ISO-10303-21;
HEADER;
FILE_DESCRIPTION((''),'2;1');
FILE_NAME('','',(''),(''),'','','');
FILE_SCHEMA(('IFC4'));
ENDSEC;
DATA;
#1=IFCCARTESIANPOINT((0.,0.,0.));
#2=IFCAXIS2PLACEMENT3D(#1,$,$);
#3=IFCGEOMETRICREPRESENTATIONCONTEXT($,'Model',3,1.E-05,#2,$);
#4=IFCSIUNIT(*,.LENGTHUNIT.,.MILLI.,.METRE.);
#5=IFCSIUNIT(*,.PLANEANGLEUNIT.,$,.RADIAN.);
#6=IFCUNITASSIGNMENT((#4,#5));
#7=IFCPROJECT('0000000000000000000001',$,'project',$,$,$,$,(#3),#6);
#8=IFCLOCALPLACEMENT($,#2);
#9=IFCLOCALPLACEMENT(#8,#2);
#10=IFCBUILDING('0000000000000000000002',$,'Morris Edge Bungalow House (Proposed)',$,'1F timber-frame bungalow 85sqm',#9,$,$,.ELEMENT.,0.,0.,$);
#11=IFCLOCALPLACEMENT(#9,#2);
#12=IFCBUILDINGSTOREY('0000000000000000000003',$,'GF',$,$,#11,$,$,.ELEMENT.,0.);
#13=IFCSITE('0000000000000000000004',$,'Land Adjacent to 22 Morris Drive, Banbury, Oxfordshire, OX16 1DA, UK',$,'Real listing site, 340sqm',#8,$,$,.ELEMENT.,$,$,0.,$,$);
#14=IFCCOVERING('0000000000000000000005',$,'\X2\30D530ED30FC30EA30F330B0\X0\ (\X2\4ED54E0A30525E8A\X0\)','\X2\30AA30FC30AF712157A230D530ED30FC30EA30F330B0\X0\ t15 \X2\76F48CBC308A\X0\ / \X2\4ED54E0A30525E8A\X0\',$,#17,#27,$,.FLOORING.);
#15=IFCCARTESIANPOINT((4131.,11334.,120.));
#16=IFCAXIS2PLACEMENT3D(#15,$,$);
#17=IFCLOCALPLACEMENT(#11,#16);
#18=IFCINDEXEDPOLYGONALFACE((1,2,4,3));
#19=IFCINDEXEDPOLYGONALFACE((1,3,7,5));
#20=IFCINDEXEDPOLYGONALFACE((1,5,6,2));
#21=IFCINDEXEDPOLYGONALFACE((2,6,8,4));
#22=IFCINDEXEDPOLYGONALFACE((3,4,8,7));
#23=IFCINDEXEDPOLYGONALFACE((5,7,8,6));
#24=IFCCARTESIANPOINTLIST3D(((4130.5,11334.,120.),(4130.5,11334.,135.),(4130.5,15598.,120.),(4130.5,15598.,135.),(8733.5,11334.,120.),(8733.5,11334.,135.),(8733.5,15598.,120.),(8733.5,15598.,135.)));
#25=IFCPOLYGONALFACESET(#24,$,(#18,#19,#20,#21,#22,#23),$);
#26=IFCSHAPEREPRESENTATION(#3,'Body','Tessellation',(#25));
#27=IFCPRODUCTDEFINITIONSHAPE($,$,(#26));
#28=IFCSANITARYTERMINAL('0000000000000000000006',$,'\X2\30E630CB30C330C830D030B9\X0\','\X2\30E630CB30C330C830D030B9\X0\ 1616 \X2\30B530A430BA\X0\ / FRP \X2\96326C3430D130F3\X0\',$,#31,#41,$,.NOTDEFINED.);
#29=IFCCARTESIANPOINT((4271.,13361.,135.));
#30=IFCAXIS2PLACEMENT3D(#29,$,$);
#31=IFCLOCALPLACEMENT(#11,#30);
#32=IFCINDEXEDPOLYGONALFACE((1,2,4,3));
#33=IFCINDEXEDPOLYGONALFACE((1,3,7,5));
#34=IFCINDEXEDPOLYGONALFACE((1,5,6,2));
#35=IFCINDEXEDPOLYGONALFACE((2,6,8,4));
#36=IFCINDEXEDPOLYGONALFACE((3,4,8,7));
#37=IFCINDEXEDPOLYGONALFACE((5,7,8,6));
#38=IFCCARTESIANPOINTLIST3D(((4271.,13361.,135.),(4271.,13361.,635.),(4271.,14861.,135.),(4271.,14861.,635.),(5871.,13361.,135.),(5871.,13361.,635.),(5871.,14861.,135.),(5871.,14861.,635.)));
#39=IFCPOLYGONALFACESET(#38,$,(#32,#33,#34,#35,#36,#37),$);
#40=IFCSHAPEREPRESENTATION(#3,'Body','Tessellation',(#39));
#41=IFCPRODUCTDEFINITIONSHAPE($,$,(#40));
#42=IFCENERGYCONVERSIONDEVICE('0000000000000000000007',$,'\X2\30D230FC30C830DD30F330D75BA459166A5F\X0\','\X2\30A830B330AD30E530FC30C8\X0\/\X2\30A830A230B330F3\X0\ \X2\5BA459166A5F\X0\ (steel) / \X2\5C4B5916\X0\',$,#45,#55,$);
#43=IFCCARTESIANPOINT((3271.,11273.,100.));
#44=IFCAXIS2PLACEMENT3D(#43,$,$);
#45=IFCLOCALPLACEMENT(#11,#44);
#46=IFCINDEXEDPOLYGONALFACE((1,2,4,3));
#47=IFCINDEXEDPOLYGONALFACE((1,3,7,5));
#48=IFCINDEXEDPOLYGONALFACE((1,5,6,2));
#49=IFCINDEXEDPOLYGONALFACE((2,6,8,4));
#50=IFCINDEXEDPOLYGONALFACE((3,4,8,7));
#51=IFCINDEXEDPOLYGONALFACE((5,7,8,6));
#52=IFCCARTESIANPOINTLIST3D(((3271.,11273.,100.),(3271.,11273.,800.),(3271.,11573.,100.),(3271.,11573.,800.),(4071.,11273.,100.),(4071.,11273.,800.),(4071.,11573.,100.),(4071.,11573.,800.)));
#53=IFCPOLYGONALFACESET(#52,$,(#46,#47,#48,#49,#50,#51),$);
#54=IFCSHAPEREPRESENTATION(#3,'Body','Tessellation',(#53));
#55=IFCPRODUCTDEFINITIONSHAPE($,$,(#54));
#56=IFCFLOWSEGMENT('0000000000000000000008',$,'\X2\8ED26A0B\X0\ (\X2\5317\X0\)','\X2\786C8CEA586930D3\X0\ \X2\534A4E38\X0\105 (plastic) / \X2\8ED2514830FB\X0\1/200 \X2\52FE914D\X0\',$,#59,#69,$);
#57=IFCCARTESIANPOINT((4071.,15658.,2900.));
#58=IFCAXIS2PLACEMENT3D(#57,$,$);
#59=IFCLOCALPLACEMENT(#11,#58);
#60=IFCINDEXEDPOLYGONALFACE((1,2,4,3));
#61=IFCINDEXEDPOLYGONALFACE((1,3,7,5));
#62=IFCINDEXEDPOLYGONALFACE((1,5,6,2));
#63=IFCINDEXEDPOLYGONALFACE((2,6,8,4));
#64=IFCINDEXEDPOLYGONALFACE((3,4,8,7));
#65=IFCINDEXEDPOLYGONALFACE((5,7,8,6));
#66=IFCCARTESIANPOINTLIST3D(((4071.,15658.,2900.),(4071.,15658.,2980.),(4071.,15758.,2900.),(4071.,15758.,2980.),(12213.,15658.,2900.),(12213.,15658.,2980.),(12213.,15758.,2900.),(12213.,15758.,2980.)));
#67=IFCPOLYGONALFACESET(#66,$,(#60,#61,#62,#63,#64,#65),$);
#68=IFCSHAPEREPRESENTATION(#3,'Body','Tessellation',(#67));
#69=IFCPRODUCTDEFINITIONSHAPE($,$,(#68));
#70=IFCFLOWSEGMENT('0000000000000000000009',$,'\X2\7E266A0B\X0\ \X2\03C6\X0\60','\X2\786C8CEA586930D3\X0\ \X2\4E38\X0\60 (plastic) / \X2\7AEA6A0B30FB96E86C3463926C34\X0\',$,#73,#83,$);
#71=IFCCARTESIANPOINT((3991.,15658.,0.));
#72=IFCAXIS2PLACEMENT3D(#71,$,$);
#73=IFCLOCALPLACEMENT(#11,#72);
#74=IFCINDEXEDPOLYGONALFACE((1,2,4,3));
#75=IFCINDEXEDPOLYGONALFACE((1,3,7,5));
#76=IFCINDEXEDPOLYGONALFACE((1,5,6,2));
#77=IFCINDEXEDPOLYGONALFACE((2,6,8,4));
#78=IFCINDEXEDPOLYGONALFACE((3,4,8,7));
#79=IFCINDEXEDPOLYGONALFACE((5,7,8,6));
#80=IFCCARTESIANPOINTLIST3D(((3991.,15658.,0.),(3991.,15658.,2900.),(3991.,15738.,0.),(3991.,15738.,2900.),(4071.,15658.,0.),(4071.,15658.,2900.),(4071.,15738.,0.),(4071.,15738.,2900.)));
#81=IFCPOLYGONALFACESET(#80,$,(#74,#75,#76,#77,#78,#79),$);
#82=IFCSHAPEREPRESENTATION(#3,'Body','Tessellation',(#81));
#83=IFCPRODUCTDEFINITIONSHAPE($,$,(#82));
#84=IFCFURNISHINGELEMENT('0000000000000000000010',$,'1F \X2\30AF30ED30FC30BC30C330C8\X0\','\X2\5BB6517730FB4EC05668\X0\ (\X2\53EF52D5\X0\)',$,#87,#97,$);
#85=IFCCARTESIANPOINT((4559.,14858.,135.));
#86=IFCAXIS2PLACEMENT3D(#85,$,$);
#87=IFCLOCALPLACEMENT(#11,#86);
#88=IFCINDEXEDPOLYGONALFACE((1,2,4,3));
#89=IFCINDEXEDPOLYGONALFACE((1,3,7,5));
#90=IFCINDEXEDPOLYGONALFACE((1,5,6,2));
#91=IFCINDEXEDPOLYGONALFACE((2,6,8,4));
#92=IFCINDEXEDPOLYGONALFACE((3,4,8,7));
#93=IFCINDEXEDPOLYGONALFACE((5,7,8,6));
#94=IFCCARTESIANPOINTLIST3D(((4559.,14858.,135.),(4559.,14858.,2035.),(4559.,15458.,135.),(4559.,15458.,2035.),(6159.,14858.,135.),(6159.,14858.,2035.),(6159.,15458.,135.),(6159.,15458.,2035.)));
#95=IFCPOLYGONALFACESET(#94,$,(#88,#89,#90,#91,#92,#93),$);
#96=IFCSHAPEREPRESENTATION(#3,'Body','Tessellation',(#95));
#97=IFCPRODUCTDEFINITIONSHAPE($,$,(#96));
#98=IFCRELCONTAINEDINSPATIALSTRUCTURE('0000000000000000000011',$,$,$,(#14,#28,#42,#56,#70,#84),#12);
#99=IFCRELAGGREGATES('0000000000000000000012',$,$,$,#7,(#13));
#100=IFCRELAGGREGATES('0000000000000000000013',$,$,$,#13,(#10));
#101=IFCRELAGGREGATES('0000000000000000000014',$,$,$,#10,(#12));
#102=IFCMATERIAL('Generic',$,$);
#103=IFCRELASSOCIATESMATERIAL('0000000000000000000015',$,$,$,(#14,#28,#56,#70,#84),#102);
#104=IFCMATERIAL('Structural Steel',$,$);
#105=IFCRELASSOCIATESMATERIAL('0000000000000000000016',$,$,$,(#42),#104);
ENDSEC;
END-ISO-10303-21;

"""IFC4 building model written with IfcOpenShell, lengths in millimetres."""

from ifc_helpers import new_model, si_unit, frame, frame_2d, origin, place, context, project, spatial, rectangle, extrude, material, element, save


model = new_model("IFC4")

# Units and contexts
model_context = context("Model", 3, precision=1e-05, world=origin())
ifc_project = project(units=[si_unit("LENGTHUNIT", "METRE", prefix="MILLI"), si_unit("PLANEANGLEUNIT", "RADIAN")], contexts=[model_context])

# Site, building, storey
site_placement = place(None, origin())
site = spatial("IfcSite", under=ifc_project, at=site_placement, Name="Land Adjacent to 22 Morris Drive, Banbury, Oxfordshire, OX16 1DA, UK", ObjectType="Real listing site, 340sqm", CompositionType="ELEMENT", RefElevation=0.0)
building_placement = place(site_placement, origin())
building = spatial("IfcBuilding", under=site, at=building_placement, Name="Morris Edge Bungalow House (Proposed)", ObjectType="1F timber-frame bungalow 85sqm", CompositionType="ELEMENT", ElevationOfRefHeight=0.0, ElevationOfTerrain=0.0)
storey_placement = place(building_placement, origin())
storey = spatial("IfcBuildingStorey", under=building, at=storey_placement, Name="GF", CompositionType="ELEMENT", Elevation=0.0)

# Shared definitions
ifc_material_1 = material(Name="Structural Steel")

# Covering
ifc_material_2 = material(Name="Generic")
covering_placement = place(storey_placement, frame((4131.0, 11334.0, 120.0)))
element("IfcCovering", 1, at=covering_placement, inside=storey, material=ifc_material_2, Name="フローリング (仕上げ床)", Description="オーク無垢フローリング t15 直貼り / 仕上げ床", PredefinedType="FLOORING", context=model_context, shape_type="SweptSolid", body=[
    extrude(rectangle(XDim=4603.0, YDim=4264.0, at=frame_2d((2301.0, 2132.0))), frame((4131.0, 11334.0, 120.0)), (0.0, 0.0, 1.0), 15.0),
])

# Sanitary terminal
sanitary_terminal_placement = place(storey_placement, frame((4271.0, 13361.0, 135.0)))
element("IfcSanitaryTerminal", 2, at=sanitary_terminal_placement, inside=storey, material=ifc_material_2, Name="ユニットバス", Description="ユニットバス 1616 サイズ / FRP 防水パン", PredefinedType="NOTDEFINED", context=model_context, shape_type="SweptSolid", body=[
    extrude(rectangle(XDim=1600.0, YDim=1500.0, at=frame_2d((800.0, 750.0))), frame((4271.0, 13361.0, 135.0)), (0.0, 0.0, 1.0), 500.0),
])

# Energy conversion device
energy_conversion_device_placement = place(storey_placement, frame((3271.0, 11273.0, 100.0)))
element("IfcEnergyConversionDevice", 3, at=energy_conversion_device_placement, inside=storey, material=ifc_material_1, Name="ヒートポンプ室外機", Description="エコキュート/エアコン 室外機 (steel) / 屋外", context=model_context, shape_type="SweptSolid", body=[
    extrude(rectangle(XDim=800.0, YDim=300.0, at=frame_2d((400.0, 150.0))), frame((3271.0, 11273.0, 100.0)), (0.0, 0.0, 1.0), 700.0),
])

# Flow segments
flow_segment_1_placement = place(storey_placement, frame((4071.0, 15658.0, 2900.0)))
element("IfcFlowSegment", 4, at=flow_segment_1_placement, inside=storey, material=ifc_material_2, Name="軒樋 (北)", Description="硬質塩ビ 半丸105 (plastic) / 軒先・1/200 勾配", context=model_context, shape_type="SweptSolid", body=[
    extrude(rectangle(XDim=8142.0, YDim=100.0, at=frame_2d((4071.0, 50.0))), frame((4071.0, 15658.0, 2900.0)), (0.0, 0.0, 1.0), 80.0),
])
flow_segment_2_placement = place(storey_placement, frame((3991.0, 15658.0, 0.0)))
element("IfcFlowSegment", 5, at=flow_segment_2_placement, inside=storey, material=ifc_material_2, Name="縦樋 φ60", Description="硬質塩ビ 丸60 (plastic) / 竪樋・雨水排水", context=model_context, shape_type="SweptSolid", body=[
    extrude(rectangle(XDim=80.0, YDim=80.0, at=frame_2d((40.0, 40.0))), frame((3991.0, 15658.0, 0.0)), (0.0, 0.0, 1.0), 2900.0),
])

# Furnishing element
furnishing_placement = place(storey_placement, frame((4559.0, 14858.0, 135.0)))
element("IfcFurnishingElement", 6, at=furnishing_placement, inside=storey, material=ifc_material_2, Name="1F クローゼット", Description="家具・什器 (可動)", context=model_context, shape_type="SweptSolid", body=[
    extrude(rectangle(XDim=1600.0, YDim=600.0, at=frame_2d((800.0, 300.0))), frame((4559.0, 14858.0, 135.0)), (0.0, 0.0, 1.0), 1900.0),
])

save(model, "model.ifc")
